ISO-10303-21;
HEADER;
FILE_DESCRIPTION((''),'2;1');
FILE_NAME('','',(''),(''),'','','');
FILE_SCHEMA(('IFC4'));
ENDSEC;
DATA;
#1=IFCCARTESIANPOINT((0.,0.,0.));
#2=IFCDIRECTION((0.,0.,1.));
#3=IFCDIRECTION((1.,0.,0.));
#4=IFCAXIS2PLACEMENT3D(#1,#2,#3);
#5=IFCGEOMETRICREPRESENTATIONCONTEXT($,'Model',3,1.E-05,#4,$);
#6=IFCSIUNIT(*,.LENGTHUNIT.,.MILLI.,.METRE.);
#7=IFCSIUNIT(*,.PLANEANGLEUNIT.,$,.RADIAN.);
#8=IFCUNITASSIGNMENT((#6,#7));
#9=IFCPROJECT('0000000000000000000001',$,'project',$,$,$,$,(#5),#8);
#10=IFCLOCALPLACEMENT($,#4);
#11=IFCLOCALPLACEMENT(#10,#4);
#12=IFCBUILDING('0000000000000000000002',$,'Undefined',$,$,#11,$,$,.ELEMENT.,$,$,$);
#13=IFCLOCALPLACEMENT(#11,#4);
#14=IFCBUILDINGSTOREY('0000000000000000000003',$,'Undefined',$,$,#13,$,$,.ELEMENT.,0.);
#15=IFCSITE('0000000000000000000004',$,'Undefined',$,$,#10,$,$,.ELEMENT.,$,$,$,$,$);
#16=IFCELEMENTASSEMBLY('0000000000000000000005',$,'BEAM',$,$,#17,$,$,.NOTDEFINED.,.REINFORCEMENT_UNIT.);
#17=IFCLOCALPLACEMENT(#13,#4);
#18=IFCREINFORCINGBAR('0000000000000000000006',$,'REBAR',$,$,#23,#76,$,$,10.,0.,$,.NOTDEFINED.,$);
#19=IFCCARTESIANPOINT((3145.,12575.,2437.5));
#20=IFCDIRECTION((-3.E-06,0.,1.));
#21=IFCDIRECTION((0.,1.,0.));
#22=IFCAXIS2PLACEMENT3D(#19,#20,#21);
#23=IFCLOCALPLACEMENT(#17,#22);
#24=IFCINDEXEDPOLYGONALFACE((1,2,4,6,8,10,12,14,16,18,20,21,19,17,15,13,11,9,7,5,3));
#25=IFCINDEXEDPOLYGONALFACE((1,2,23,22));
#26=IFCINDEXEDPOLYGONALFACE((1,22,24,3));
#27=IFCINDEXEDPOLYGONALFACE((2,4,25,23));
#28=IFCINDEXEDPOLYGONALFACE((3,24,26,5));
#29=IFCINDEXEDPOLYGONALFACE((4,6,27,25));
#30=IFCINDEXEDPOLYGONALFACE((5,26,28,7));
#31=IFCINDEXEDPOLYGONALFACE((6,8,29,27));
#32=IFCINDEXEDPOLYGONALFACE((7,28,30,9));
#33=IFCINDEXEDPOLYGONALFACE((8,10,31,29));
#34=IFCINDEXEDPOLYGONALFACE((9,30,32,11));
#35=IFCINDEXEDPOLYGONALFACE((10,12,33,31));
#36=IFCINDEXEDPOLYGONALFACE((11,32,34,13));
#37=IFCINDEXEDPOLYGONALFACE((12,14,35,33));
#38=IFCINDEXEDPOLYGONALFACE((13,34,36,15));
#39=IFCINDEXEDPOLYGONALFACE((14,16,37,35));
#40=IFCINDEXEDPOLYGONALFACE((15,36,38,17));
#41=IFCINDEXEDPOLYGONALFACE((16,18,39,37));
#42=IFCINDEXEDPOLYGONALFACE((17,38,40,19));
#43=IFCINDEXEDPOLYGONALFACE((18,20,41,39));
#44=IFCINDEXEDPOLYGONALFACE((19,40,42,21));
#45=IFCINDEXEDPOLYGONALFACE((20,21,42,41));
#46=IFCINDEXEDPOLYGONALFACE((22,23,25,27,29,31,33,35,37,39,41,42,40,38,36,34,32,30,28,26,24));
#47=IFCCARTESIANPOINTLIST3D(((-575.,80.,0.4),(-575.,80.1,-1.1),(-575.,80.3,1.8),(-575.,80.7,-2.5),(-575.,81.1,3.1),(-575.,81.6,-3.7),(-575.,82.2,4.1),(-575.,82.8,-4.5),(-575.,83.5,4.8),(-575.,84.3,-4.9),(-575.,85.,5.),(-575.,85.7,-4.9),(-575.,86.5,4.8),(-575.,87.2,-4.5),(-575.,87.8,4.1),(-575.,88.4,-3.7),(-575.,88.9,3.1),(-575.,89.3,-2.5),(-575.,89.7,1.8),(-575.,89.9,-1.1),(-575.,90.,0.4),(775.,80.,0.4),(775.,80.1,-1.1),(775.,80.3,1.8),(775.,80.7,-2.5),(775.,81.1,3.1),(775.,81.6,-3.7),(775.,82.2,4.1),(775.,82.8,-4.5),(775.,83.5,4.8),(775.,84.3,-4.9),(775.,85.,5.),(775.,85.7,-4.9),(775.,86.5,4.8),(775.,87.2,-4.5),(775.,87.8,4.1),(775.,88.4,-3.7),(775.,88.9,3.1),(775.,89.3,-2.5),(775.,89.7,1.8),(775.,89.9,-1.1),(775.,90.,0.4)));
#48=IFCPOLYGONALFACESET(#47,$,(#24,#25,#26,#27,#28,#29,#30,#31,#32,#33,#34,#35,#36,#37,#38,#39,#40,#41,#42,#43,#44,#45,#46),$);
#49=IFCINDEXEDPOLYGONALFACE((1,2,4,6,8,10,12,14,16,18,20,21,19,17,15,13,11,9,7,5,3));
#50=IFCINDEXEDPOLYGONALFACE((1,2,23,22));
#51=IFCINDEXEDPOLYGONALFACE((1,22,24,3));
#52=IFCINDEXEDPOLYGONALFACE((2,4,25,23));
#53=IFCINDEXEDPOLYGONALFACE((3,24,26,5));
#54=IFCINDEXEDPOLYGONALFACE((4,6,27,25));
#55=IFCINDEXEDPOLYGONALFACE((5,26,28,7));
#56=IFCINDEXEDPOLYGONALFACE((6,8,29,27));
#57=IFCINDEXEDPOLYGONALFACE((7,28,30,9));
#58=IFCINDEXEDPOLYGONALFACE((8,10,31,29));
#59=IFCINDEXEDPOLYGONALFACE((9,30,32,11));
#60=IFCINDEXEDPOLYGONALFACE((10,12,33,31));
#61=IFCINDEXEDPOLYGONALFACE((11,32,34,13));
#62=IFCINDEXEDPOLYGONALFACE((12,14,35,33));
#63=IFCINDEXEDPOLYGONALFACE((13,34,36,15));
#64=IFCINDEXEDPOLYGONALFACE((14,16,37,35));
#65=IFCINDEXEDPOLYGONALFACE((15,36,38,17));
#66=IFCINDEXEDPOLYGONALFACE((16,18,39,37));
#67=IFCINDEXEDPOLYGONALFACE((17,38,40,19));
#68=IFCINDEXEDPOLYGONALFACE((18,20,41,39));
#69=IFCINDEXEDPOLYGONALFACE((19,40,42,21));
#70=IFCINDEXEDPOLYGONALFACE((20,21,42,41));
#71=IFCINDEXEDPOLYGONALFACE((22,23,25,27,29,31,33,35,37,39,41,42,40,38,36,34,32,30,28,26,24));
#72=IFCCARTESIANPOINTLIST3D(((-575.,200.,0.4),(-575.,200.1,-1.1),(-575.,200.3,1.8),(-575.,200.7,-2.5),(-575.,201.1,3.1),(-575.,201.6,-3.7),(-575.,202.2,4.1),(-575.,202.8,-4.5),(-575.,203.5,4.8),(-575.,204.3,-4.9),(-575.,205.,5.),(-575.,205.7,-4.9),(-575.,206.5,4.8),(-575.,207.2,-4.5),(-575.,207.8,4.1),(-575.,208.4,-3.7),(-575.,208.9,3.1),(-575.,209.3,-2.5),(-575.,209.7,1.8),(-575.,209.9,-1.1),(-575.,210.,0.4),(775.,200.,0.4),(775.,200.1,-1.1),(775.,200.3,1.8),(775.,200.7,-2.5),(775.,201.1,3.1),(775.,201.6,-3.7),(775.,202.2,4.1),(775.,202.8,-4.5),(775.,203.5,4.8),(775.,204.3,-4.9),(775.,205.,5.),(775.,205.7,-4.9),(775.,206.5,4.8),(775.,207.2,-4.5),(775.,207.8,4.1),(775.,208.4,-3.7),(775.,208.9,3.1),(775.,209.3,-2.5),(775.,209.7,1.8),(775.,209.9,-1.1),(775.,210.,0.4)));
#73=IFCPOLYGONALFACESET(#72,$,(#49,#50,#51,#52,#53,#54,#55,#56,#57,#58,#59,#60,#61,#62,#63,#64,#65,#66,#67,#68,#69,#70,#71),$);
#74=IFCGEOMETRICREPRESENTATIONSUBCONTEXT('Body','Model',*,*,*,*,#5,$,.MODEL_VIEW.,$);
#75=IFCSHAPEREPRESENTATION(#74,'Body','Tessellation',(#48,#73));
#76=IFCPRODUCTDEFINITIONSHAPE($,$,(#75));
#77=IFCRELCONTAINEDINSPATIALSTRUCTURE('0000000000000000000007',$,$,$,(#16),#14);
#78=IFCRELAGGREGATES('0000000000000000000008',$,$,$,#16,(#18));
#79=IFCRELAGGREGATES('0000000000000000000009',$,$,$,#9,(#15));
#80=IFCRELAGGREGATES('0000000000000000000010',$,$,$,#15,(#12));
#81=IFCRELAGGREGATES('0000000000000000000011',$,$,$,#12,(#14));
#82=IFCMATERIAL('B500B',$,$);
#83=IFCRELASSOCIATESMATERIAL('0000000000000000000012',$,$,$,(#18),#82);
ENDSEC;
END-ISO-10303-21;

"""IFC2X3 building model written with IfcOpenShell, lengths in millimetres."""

from ifc_helpers import new_model, entity, si_unit, frame, origin_with_axes, place, context, subcontext, project, spatial, source, transform, mapped, material, element, aggregate, save


model = new_model("IFC2X3")

# Units and contexts
model_context = context("Model", 3, precision=1e-05, world=origin_with_axes())
body_context = subcontext(model_context, "Body", "Model", "MODEL_VIEW")
ifc_project = project(units=[si_unit("LENGTHUNIT", "METRE", prefix="MILLI"), si_unit("PLANEANGLEUNIT", "RADIAN")], contexts=[model_context])

# Site, building, storey
site_placement = place(None, origin_with_axes())
site = spatial("IfcSite", under=ifc_project, at=site_placement, Name="Undefined", CompositionType="ELEMENT")
building_placement = place(site_placement, origin_with_axes())
building = spatial("IfcBuilding", under=site, at=building_placement, Name="Undefined", CompositionType="ELEMENT")
storey_placement = place(building_placement, origin_with_axes())
storey = spatial("IfcBuildingStorey", under=building, at=storey_placement, Name="Undefined", CompositionType="ELEMENT", Elevation=0.0)

# Shared definitions
ifc_material_1 = material(Name="B500B")

# Element assembly, reinforcing bar
assembly_1_placement = place(storey_placement, origin_with_axes())
assembly_1 = element("IfcElementAssembly", 1, at=assembly_1_placement, inside=storey, Name="BEAM", AssemblyPlace="NOTDEFINED", PredefinedType="REINFORCEMENT_UNIT")
shared_shape_1 = source(origin_with_axes(), body_context, "Body", "AdvancedSweptSolid", [
    entity("IfcSweptDiskSolid", entity("IfcTrimmedCurve", entity("IfcLine", entity("IfcCartesianPoint", [0.0, 0.0, 0.0]), entity("IfcVector", entity("IfcDirection", [1.0, 0.0, 0.0]), 1.0)), [entity("IfcParameterValue", 0.0)], [entity("IfcParameterValue", 1349.999613)], True, "PARAMETER"), 5.0, None, 0.0, 1350.0),
])
shared_shape_2 = source(origin_with_axes(), body_context, "Body", "AdvancedSweptSolid", [
    entity("IfcSweptDiskSolid", entity("IfcTrimmedCurve", entity("IfcLine", entity("IfcCartesianPoint", [0.0, 0.0, 0.0]), entity("IfcVector", entity("IfcDirection", [1.0, 0.0, 0.0]), 1.0)), [entity("IfcParameterValue", 0.0)], [entity("IfcParameterValue", 1349.999613)], True, "PARAMETER"), 5.0, None, 0.0, 1350.0),
])
reinforcing_bar_1_placement = place(assembly_1_placement, frame((3145.0, 12575.0, 2437.5), z_axis=(-0.000003, 0.0, 1.0), x_axis=(0.0, 1.0, 0.0)))
reinforcing_bar_1 = element("IfcReinforcingBar", 2, at=reinforcing_bar_1_placement, material=ifc_material_1, Name="REBAR", BarRole="NOTDEFINED", CrossSectionArea=0.0, NominalDiameter=10.0, context=body_context, shape_type="MappedRepresentation", body=[
    mapped(shared_shape_1, transform((-575.0, 85.0, 0.0))),
    mapped(shared_shape_2, transform((-575.0, 205.0, 0.0))),
])
aggregate(assembly_1, [reinforcing_bar_1])

save(model, "model.ifc")
